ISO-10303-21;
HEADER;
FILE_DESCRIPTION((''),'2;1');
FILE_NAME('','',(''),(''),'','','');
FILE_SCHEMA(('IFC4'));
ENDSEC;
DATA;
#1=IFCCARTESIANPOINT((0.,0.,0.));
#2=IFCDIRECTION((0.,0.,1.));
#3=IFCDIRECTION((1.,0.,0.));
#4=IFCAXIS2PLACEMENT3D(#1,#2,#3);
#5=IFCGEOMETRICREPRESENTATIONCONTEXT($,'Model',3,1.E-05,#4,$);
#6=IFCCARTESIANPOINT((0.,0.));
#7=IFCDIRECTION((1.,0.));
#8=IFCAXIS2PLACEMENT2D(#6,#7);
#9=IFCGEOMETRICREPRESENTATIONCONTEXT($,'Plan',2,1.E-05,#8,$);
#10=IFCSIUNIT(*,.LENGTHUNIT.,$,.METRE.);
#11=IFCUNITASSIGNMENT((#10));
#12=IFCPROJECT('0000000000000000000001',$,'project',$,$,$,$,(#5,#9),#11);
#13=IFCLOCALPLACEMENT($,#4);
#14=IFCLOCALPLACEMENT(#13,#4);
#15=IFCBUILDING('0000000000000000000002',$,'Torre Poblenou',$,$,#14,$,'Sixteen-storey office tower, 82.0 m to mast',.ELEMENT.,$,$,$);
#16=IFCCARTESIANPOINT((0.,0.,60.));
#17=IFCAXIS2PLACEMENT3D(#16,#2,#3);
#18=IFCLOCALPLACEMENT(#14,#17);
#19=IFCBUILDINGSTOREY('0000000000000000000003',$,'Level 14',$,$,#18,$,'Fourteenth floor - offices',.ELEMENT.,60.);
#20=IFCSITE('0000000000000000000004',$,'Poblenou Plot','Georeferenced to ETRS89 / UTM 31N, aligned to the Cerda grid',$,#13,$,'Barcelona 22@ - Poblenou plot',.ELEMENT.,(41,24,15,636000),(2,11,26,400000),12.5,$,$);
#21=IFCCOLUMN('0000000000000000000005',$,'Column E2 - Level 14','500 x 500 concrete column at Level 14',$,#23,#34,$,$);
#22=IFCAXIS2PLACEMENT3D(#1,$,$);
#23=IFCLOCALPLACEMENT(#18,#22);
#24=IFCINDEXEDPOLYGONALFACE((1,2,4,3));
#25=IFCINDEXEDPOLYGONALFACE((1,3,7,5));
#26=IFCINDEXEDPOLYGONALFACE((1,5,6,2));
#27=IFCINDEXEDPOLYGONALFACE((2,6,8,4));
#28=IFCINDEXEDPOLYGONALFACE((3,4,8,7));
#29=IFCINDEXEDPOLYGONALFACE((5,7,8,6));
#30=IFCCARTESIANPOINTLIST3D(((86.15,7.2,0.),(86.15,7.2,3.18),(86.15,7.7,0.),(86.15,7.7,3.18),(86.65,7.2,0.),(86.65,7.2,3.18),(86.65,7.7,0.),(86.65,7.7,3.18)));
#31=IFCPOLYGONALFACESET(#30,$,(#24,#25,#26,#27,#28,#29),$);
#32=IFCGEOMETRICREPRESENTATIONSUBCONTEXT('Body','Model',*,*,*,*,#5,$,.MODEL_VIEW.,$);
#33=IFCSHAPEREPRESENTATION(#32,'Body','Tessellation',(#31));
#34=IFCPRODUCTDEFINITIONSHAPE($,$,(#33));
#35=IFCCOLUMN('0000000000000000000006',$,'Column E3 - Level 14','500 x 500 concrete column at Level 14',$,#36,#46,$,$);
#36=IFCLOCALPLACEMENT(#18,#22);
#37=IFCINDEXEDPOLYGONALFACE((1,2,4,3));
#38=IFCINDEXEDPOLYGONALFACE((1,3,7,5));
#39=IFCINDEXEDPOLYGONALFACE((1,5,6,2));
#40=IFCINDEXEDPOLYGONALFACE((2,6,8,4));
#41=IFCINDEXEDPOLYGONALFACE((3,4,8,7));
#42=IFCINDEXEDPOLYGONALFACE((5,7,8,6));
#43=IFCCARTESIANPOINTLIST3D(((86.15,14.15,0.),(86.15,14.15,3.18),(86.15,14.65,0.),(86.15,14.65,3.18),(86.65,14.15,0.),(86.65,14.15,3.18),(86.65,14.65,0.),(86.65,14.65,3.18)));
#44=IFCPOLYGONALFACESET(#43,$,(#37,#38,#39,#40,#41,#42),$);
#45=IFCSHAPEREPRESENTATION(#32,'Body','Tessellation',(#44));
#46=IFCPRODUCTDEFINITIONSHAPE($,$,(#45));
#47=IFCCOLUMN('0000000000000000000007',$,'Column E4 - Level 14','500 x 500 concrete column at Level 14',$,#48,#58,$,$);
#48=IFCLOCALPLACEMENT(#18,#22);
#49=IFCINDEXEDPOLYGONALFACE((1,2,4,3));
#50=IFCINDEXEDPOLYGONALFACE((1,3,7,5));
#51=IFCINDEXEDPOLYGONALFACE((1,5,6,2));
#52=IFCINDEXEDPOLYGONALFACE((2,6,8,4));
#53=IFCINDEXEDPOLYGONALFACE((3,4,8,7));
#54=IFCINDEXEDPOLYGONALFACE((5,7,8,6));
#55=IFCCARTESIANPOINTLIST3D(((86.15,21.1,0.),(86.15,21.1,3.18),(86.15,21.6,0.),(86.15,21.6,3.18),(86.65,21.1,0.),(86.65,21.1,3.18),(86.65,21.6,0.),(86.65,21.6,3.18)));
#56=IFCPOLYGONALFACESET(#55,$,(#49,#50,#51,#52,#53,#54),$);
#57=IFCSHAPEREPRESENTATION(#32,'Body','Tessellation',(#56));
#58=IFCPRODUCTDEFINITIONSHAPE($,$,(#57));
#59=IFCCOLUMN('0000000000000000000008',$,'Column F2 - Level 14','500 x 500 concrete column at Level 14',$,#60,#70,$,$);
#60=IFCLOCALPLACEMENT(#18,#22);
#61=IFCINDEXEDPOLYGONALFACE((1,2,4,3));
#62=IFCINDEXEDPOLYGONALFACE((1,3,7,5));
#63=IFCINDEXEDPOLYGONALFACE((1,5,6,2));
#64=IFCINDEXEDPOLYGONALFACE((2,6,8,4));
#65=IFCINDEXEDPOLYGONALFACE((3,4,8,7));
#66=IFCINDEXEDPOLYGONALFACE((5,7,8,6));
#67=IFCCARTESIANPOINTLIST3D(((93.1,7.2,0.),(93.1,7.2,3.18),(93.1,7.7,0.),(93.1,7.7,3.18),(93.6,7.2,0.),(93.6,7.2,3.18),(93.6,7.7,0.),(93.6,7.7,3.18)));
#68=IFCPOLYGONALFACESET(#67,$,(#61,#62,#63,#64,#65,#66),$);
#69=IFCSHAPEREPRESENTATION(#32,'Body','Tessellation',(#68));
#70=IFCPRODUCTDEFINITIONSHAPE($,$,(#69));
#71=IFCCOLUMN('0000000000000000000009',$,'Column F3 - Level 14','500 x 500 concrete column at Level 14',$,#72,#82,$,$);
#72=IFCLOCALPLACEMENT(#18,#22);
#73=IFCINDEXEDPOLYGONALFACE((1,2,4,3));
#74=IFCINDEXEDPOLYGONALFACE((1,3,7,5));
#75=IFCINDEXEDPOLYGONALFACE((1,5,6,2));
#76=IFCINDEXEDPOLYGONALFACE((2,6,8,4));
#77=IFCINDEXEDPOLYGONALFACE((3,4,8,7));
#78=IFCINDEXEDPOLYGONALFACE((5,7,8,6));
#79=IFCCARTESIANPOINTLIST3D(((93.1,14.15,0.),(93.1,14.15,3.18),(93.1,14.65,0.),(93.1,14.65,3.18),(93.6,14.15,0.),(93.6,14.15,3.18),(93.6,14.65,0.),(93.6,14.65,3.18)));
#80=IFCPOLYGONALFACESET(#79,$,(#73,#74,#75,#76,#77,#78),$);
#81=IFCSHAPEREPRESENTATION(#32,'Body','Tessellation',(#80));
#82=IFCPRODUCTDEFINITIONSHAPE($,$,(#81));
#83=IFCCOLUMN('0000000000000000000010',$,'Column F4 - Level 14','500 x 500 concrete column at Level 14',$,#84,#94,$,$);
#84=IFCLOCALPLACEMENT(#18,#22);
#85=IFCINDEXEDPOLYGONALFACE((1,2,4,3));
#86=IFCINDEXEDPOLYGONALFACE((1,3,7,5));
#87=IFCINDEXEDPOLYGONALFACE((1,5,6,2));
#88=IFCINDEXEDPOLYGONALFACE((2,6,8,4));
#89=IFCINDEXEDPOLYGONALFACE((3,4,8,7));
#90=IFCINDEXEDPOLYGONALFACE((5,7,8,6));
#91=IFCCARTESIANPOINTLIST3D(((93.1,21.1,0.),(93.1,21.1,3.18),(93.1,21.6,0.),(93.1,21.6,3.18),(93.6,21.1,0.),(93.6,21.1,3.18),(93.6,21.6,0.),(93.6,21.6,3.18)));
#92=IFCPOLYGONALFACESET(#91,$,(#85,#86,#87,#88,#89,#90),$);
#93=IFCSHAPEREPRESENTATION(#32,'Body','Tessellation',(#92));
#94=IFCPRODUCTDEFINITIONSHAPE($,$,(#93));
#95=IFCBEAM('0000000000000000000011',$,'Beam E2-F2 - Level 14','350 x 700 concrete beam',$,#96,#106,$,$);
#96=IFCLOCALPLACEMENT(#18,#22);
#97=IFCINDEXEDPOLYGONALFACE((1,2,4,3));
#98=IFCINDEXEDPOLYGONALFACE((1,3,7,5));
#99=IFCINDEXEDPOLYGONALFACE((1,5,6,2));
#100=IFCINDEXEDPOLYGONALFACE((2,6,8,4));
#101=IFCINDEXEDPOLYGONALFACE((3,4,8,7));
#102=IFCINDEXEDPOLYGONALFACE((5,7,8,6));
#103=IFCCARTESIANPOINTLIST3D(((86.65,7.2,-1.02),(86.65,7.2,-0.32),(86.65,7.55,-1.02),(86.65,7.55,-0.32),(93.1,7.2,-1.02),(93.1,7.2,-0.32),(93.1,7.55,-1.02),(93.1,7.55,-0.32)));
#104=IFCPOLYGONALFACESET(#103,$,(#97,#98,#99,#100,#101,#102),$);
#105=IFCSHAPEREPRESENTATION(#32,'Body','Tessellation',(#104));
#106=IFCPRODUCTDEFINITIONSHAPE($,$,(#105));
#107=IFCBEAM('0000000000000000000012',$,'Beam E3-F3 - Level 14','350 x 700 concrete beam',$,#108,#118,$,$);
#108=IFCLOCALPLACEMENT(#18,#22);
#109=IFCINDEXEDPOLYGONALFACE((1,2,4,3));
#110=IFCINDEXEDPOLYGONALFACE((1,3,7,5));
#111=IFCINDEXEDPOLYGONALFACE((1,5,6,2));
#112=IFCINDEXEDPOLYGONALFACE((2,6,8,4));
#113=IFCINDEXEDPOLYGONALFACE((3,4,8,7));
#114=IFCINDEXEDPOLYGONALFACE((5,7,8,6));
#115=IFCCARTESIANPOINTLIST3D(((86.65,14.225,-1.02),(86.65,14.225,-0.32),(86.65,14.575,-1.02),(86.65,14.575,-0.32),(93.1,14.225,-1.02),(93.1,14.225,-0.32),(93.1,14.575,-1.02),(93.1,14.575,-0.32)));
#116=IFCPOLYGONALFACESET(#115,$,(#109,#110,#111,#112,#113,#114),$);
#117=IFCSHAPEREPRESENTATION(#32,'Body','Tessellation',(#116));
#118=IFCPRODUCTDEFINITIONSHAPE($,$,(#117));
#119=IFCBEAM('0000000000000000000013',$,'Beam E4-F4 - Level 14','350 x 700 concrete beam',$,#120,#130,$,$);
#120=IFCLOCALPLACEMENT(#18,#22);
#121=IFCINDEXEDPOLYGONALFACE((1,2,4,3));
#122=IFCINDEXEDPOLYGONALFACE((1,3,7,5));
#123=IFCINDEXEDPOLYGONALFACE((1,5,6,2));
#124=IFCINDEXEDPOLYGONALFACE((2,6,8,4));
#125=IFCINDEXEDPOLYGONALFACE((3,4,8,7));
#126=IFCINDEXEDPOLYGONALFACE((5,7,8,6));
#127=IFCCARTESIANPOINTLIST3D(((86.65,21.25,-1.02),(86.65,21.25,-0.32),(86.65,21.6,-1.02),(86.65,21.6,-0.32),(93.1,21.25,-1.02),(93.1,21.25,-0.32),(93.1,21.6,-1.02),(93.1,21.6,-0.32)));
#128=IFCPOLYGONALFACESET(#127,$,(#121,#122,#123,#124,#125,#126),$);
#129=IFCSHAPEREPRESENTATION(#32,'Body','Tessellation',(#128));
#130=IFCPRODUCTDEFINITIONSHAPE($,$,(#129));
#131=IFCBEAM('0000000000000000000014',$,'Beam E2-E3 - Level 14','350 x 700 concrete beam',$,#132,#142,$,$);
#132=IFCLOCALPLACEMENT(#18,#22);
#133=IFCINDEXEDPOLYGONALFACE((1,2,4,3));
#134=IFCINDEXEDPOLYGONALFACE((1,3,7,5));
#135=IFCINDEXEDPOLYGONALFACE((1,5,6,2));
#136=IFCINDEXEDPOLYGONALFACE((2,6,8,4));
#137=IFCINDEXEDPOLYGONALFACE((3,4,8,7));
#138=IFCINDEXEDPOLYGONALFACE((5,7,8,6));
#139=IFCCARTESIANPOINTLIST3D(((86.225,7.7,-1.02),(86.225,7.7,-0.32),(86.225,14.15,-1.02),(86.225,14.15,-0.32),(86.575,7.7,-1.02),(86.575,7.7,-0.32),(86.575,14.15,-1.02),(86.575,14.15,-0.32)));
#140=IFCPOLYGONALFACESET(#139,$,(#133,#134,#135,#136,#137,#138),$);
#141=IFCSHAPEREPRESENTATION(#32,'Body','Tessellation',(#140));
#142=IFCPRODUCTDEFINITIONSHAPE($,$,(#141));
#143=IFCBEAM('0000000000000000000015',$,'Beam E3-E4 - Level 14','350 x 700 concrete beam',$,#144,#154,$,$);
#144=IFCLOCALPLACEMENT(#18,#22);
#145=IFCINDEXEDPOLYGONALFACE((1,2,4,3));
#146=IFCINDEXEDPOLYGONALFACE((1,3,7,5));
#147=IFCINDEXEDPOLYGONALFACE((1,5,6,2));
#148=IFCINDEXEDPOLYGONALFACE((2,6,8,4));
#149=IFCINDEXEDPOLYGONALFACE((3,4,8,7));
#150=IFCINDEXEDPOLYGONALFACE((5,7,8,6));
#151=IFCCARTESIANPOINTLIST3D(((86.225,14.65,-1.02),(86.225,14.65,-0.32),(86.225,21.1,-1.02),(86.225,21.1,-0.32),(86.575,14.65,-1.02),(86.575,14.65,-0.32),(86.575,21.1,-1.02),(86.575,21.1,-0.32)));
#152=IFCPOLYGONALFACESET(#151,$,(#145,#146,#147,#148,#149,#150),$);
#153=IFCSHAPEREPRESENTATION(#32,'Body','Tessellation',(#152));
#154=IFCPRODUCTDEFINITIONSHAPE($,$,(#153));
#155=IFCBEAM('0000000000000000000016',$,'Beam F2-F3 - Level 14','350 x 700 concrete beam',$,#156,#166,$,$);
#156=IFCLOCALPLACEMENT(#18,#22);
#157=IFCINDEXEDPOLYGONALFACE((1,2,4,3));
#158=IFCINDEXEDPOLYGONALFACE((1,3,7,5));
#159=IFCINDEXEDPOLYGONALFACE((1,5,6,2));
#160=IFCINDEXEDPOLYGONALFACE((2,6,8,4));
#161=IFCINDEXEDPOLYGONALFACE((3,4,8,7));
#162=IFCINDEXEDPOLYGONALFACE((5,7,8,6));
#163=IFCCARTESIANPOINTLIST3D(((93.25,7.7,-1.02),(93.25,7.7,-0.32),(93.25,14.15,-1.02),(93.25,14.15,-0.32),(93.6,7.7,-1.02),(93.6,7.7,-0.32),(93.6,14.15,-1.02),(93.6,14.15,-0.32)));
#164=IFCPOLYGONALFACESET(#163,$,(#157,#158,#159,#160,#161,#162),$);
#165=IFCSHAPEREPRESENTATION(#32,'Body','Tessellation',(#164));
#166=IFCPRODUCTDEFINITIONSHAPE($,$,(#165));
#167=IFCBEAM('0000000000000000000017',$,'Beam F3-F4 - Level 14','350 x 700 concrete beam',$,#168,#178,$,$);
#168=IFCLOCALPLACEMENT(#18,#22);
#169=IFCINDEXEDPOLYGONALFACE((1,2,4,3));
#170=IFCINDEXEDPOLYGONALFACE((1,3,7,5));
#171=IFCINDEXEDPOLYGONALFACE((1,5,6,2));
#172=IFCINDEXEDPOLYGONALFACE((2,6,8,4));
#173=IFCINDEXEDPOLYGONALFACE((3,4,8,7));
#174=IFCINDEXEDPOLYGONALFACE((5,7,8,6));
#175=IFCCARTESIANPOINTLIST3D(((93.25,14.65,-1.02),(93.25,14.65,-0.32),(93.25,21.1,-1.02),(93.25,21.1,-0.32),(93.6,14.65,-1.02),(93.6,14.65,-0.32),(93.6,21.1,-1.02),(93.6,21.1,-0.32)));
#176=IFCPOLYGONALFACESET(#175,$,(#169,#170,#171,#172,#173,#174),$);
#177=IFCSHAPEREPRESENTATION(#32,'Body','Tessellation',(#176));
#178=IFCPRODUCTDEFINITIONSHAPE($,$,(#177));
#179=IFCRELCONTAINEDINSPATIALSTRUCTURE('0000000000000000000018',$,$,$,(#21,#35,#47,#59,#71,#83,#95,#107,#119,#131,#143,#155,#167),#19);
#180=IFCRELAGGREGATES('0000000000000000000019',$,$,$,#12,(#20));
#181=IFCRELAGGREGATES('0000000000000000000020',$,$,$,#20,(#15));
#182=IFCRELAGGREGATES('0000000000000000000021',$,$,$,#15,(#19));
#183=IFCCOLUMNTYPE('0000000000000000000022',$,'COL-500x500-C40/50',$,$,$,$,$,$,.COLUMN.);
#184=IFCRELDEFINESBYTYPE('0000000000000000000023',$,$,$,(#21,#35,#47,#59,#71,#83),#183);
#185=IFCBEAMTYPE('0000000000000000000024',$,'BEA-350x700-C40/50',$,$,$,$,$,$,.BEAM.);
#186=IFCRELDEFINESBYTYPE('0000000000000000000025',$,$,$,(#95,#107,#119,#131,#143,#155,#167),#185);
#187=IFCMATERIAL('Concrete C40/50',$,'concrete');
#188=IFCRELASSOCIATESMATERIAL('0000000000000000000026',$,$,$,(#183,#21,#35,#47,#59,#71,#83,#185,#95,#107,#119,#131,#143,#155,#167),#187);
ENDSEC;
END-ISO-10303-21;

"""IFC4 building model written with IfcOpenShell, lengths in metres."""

from ifc_helpers import new_model, si_unit, frame, origin_with_axes, origin_2d_with_axis, place, context, subcontext, project, spatial, line, indexed_curve, rectangle, outline, extrude, material, material_profile, profile_set, profile_usage, type_object, element, save


model = new_model("IFC4")

# Units and contexts
model_context = context("Model", 3, precision=1e-05, world=origin_with_axes())
plan_context = context("Plan", 2, precision=1e-05, world=origin_2d_with_axis())
body_context = subcontext(model_context, "Body", "Model", "MODEL_VIEW")
ifc_project = project(units=[si_unit("LENGTHUNIT", "METRE")], contexts=[model_context, plan_context])

# Site, building, storey
site_placement = place(None, origin_with_axes())
site = spatial("IfcSite", under=ifc_project, at=site_placement, Name="Poblenou Plot", Description="Georeferenced to ETRS89 / UTM 31N, aligned to the Cerda grid", LongName="Barcelona 22@ - Poblenou plot", CompositionType="ELEMENT", RefLatitude=(41, 24, 15, 636000), RefLongitude=(2, 11, 26, 400000), RefElevation=12.5)
building_placement = place(site_placement, origin_with_axes())
building = spatial("IfcBuilding", under=site, at=building_placement, Name="Torre Poblenou", LongName="Sixteen-storey office tower, 82.0 m to mast", CompositionType="ELEMENT")
storey_placement = place(building_placement, frame((0.0, 0.0, 60.0), z_axis=(0.0, 0.0, 1.0), x_axis=(1.0, 0.0, 0.0)))
storey = spatial("IfcBuildingStorey", under=building, at=storey_placement, Name="Level 14", LongName="Fourteenth floor - offices", CompositionType="ELEMENT", Elevation=60.0)

# Columns
ifc_material_1 = material(Name="Concrete C40/50", Category="concrete")
ifc_material_profile_1 = material_profile(ifc_material_1, rectangle(XDim=0.5, YDim=0.5))
ifc_profile_set_1 = profile_set([ifc_material_profile_1], Name="COL-500x500-C40/50")
ifc_profile_usage_1 = profile_usage(ifc_profile_set_1)
column_type = type_object("IfcColumnType", Name="COL-500x500-C40/50", PredefinedType="COLUMN", material=ifc_profile_set_1)
column_1_placement = place(storey_placement, frame((86.15, 7.2, 0.0), z_axis=(0.0, 0.0, 1.0), x_axis=(1.0, 0.0, 0.0)))
element("IfcColumn", 1, at=column_1_placement, inside=storey, type_object=column_type, material=ifc_profile_usage_1, Name="Column E2 - Level 14", Description="500 x 500 concrete column at Level 14", context=body_context, shape_type="SweptSolid", body=[
    extrude(outline(indexed_curve([(0.0, 0.0), (0.5, 0.0), (0.5, 0.5), (0.0, 0.5)], segments=[line(1, 2, 3, 4, 1)])), origin_with_axes(), (0.0, 0.0, 1.0), 3.18),
])
ifc_profile_usage_2 = profile_usage(ifc_profile_set_1)
column_2_placement = place(storey_placement, frame((86.15, 14.15, 0.0), z_axis=(0.0, 0.0, 1.0), x_axis=(1.0, 0.0, 0.0)))
element("IfcColumn", 2, at=column_2_placement, inside=storey, type_object=column_type, material=ifc_profile_usage_2, Name="Column E3 - Level 14", Description="500 x 500 concrete column at Level 14", context=body_context, shape_type="SweptSolid", body=[
    extrude(outline(indexed_curve([(0.0, 0.0), (0.5, 0.0), (0.5, 0.5), (0.0, 0.5)], segments=[line(1, 2, 3, 4, 1)])), origin_with_axes(), (0.0, 0.0, 1.0), 3.18),
])
ifc_profile_usage_3 = profile_usage(ifc_profile_set_1)
column_3_placement = place(storey_placement, frame((86.15, 21.1, 0.0), z_axis=(0.0, 0.0, 1.0), x_axis=(1.0, 0.0, 0.0)))
element("IfcColumn", 3, at=column_3_placement, inside=storey, type_object=column_type, material=ifc_profile_usage_3, Name="Column E4 - Level 14", Description="500 x 500 concrete column at Level 14", context=body_context, shape_type="SweptSolid", body=[
    extrude(outline(indexed_curve([(0.0, 0.0), (0.5, 0.0), (0.5, 0.5), (0.0, 0.5)], segments=[line(1, 2, 3, 4, 1)])), origin_with_axes(), (0.0, 0.0, 1.0), 3.18),
])
ifc_profile_usage_4 = profile_usage(ifc_profile_set_1)
column_4_placement = place(storey_placement, frame((93.1, 7.2, 0.0), z_axis=(0.0, 0.0, 1.0), x_axis=(1.0, 0.0, 0.0)))
element("IfcColumn", 4, at=column_4_placement, inside=storey, type_object=column_type, material=ifc_profile_usage_4, Name="Column F2 - Level 14", Description="500 x 500 concrete column at Level 14", context=body_context, shape_type="SweptSolid", body=[
    extrude(outline(indexed_curve([(0.0, 0.0), (0.5, 0.0), (0.5, 0.5), (0.0, 0.5)], segments=[line(1, 2, 3, 4, 1)])), origin_with_axes(), (0.0, 0.0, 1.0), 3.18),
])
ifc_profile_usage_5 = profile_usage(ifc_profile_set_1)
column_5_placement = place(storey_placement, frame((93.1, 14.15, 0.0), z_axis=(0.0, 0.0, 1.0), x_axis=(1.0, 0.0, 0.0)))
element("IfcColumn", 5, at=column_5_placement, inside=storey, type_object=column_type, material=ifc_profile_usage_5, Name="Column F3 - Level 14", Description="500 x 500 concrete column at Level 14", context=body_context, shape_type="SweptSolid", body=[
    extrude(outline(indexed_curve([(0.0, 0.0), (0.5, 0.0), (0.5, 0.5), (0.0, 0.5)], segments=[line(1, 2, 3, 4, 1)])), origin_with_axes(), (0.0, 0.0, 1.0), 3.18),
])
ifc_profile_usage_6 = profile_usage(ifc_profile_set_1)
column_6_placement = place(storey_placement, frame((93.1, 21.1, 0.0), z_axis=(0.0, 0.0, 1.0), x_axis=(1.0, 0.0, 0.0)))
element("IfcColumn", 6, at=column_6_placement, inside=storey, type_object=column_type, material=ifc_profile_usage_6, Name="Column F4 - Level 14", Description="500 x 500 concrete column at Level 14", context=body_context, shape_type="SweptSolid", body=[
    extrude(outline(indexed_curve([(0.0, 0.0), (0.5, 0.0), (0.5, 0.5), (0.0, 0.5)], segments=[line(1, 2, 3, 4, 1)])), origin_with_axes(), (0.0, 0.0, 1.0), 3.18),
])

# Beams
ifc_material_profile_2 = material_profile(ifc_material_1, rectangle(XDim=0.35, YDim=0.7))
ifc_profile_set_2 = profile_set([ifc_material_profile_2], Name="BEA-350x700-C40/50")
ifc_profile_usage_7 = profile_usage(ifc_profile_set_2)
beam_type = type_object("IfcBeamType", Name="BEA-350x700-C40/50", PredefinedType="BEAM", material=ifc_profile_set_2)
beam_1_placement = place(storey_placement, frame((86.65, 7.2, -1.02), z_axis=(0.0, 0.0, 1.0), x_axis=(1.0, 0.0, 0.0)))
element("IfcBeam", 7, at=beam_1_placement, inside=storey, type_object=beam_type, material=ifc_profile_usage_7, Name="Beam E2-F2 - Level 14", Description="350 x 700 concrete beam", context=body_context, shape_type="SweptSolid", body=[
    extrude(outline(indexed_curve([(0.0, 0.0), (6.45, 0.0), (6.45, 0.35), (0.0, 0.35)], segments=[line(1, 2, 3, 4, 1)])), origin_with_axes(), (0.0, 0.0, 1.0), 0.7),
])
ifc_profile_usage_8 = profile_usage(ifc_profile_set_2)
beam_2_placement = place(storey_placement, frame((86.65, 14.225, -1.02), z_axis=(0.0, 0.0, 1.0), x_axis=(1.0, 0.0, 0.0)))
element("IfcBeam", 8, at=beam_2_placement, inside=storey, type_object=beam_type, material=ifc_profile_usage_8, Name="Beam E3-F3 - Level 14", Description="350 x 700 concrete beam", context=body_context, shape_type="SweptSolid", body=[
    extrude(outline(indexed_curve([(0.0, 0.0), (6.45, 0.0), (6.45, 0.35), (0.0, 0.35)], segments=[line(1, 2, 3, 4, 1)])), origin_with_axes(), (0.0, 0.0, 1.0), 0.7),
])
ifc_profile_usage_9 = profile_usage(ifc_profile_set_2)
beam_3_placement = place(storey_placement, frame((86.65, 21.25, -1.02), z_axis=(0.0, 0.0, 1.0), x_axis=(1.0, 0.0, 0.0)))
element("IfcBeam", 9, at=beam_3_placement, inside=storey, type_object=beam_type, material=ifc_profile_usage_9, Name="Beam E4-F4 - Level 14", Description="350 x 700 concrete beam", context=body_context, shape_type="SweptSolid", body=[
    extrude(outline(indexed_curve([(0.0, 0.0), (6.45, 0.0), (6.45, 0.35), (0.0, 0.35)], segments=[line(1, 2, 3, 4, 1)])), origin_with_axes(), (0.0, 0.0, 1.0), 0.7),
])
ifc_profile_usage_10 = profile_usage(ifc_profile_set_2)
beam_4_placement = place(storey_placement, frame((86.575, 7.7, -1.02), z_axis=(0.0, 0.0, 1.0), x_axis=(0.0, 1.0, 0.0)))
element("IfcBeam", 10, at=beam_4_placement, inside=storey, type_object=beam_type, material=ifc_profile_usage_10, Name="Beam E2-E3 - Level 14", Description="350 x 700 concrete beam", context=body_context, shape_type="SweptSolid", body=[
    extrude(outline(indexed_curve([(0.0, 0.0), (6.45, 0.0), (6.45, 0.35), (0.0, 0.35)], segments=[line(1, 2, 3, 4, 1)])), origin_with_axes(), (0.0, 0.0, 1.0), 0.7),
])
ifc_profile_usage_11 = profile_usage(ifc_profile_set_2)
beam_5_placement = place(storey_placement, frame((86.575, 14.65, -1.02), z_axis=(0.0, 0.0, 1.0), x_axis=(0.0, 1.0, 0.0)))
element("IfcBeam", 11, at=beam_5_placement, inside=storey, type_object=beam_type, material=ifc_profile_usage_11, Name="Beam E3-E4 - Level 14", Description="350 x 700 concrete beam", context=body_context, shape_type="SweptSolid", body=[
    extrude(outline(indexed_curve([(0.0, 0.0), (6.45, 0.0), (6.45, 0.35), (0.0, 0.35)], segments=[line(1, 2, 3, 4, 1)])), origin_with_axes(), (0.0, 0.0, 1.0), 0.7),
])
ifc_profile_usage_12 = profile_usage(ifc_profile_set_2)
beam_6_placement = place(storey_placement, frame((93.6, 7.7, -1.02), z_axis=(0.0, 0.0, 1.0), x_axis=(0.0, 1.0, 0.0)))
element("IfcBeam", 12, at=beam_6_placement, inside=storey, type_object=beam_type, material=ifc_profile_usage_12, Name="Beam F2-F3 - Level 14", Description="350 x 700 concrete beam", context=body_context, shape_type="SweptSolid", body=[
    extrude(outline(indexed_curve([(0.0, 0.0), (6.45, 0.0), (6.45, 0.35), (0.0, 0.35)], segments=[line(1, 2, 3, 4, 1)])), origin_with_axes(), (0.0, 0.0, 1.0), 0.7),
])
ifc_profile_usage_13 = profile_usage(ifc_profile_set_2)
beam_7_placement = place(storey_placement, frame((93.6, 14.65, -1.02), z_axis=(0.0, 0.0, 1.0), x_axis=(0.0, 1.0, 0.0)))
element("IfcBeam", 13, at=beam_7_placement, inside=storey, type_object=beam_type, material=ifc_profile_usage_13, Name="Beam F3-F4 - Level 14", Description="350 x 700 concrete beam", context=body_context, shape_type="SweptSolid", body=[
    extrude(outline(indexed_curve([(0.0, 0.0), (6.45, 0.0), (6.45, 0.35), (0.0, 0.35)], segments=[line(1, 2, 3, 4, 1)])), origin_with_axes(), (0.0, 0.0, 1.0), 0.7),
])

save(model, "model.ifc")
